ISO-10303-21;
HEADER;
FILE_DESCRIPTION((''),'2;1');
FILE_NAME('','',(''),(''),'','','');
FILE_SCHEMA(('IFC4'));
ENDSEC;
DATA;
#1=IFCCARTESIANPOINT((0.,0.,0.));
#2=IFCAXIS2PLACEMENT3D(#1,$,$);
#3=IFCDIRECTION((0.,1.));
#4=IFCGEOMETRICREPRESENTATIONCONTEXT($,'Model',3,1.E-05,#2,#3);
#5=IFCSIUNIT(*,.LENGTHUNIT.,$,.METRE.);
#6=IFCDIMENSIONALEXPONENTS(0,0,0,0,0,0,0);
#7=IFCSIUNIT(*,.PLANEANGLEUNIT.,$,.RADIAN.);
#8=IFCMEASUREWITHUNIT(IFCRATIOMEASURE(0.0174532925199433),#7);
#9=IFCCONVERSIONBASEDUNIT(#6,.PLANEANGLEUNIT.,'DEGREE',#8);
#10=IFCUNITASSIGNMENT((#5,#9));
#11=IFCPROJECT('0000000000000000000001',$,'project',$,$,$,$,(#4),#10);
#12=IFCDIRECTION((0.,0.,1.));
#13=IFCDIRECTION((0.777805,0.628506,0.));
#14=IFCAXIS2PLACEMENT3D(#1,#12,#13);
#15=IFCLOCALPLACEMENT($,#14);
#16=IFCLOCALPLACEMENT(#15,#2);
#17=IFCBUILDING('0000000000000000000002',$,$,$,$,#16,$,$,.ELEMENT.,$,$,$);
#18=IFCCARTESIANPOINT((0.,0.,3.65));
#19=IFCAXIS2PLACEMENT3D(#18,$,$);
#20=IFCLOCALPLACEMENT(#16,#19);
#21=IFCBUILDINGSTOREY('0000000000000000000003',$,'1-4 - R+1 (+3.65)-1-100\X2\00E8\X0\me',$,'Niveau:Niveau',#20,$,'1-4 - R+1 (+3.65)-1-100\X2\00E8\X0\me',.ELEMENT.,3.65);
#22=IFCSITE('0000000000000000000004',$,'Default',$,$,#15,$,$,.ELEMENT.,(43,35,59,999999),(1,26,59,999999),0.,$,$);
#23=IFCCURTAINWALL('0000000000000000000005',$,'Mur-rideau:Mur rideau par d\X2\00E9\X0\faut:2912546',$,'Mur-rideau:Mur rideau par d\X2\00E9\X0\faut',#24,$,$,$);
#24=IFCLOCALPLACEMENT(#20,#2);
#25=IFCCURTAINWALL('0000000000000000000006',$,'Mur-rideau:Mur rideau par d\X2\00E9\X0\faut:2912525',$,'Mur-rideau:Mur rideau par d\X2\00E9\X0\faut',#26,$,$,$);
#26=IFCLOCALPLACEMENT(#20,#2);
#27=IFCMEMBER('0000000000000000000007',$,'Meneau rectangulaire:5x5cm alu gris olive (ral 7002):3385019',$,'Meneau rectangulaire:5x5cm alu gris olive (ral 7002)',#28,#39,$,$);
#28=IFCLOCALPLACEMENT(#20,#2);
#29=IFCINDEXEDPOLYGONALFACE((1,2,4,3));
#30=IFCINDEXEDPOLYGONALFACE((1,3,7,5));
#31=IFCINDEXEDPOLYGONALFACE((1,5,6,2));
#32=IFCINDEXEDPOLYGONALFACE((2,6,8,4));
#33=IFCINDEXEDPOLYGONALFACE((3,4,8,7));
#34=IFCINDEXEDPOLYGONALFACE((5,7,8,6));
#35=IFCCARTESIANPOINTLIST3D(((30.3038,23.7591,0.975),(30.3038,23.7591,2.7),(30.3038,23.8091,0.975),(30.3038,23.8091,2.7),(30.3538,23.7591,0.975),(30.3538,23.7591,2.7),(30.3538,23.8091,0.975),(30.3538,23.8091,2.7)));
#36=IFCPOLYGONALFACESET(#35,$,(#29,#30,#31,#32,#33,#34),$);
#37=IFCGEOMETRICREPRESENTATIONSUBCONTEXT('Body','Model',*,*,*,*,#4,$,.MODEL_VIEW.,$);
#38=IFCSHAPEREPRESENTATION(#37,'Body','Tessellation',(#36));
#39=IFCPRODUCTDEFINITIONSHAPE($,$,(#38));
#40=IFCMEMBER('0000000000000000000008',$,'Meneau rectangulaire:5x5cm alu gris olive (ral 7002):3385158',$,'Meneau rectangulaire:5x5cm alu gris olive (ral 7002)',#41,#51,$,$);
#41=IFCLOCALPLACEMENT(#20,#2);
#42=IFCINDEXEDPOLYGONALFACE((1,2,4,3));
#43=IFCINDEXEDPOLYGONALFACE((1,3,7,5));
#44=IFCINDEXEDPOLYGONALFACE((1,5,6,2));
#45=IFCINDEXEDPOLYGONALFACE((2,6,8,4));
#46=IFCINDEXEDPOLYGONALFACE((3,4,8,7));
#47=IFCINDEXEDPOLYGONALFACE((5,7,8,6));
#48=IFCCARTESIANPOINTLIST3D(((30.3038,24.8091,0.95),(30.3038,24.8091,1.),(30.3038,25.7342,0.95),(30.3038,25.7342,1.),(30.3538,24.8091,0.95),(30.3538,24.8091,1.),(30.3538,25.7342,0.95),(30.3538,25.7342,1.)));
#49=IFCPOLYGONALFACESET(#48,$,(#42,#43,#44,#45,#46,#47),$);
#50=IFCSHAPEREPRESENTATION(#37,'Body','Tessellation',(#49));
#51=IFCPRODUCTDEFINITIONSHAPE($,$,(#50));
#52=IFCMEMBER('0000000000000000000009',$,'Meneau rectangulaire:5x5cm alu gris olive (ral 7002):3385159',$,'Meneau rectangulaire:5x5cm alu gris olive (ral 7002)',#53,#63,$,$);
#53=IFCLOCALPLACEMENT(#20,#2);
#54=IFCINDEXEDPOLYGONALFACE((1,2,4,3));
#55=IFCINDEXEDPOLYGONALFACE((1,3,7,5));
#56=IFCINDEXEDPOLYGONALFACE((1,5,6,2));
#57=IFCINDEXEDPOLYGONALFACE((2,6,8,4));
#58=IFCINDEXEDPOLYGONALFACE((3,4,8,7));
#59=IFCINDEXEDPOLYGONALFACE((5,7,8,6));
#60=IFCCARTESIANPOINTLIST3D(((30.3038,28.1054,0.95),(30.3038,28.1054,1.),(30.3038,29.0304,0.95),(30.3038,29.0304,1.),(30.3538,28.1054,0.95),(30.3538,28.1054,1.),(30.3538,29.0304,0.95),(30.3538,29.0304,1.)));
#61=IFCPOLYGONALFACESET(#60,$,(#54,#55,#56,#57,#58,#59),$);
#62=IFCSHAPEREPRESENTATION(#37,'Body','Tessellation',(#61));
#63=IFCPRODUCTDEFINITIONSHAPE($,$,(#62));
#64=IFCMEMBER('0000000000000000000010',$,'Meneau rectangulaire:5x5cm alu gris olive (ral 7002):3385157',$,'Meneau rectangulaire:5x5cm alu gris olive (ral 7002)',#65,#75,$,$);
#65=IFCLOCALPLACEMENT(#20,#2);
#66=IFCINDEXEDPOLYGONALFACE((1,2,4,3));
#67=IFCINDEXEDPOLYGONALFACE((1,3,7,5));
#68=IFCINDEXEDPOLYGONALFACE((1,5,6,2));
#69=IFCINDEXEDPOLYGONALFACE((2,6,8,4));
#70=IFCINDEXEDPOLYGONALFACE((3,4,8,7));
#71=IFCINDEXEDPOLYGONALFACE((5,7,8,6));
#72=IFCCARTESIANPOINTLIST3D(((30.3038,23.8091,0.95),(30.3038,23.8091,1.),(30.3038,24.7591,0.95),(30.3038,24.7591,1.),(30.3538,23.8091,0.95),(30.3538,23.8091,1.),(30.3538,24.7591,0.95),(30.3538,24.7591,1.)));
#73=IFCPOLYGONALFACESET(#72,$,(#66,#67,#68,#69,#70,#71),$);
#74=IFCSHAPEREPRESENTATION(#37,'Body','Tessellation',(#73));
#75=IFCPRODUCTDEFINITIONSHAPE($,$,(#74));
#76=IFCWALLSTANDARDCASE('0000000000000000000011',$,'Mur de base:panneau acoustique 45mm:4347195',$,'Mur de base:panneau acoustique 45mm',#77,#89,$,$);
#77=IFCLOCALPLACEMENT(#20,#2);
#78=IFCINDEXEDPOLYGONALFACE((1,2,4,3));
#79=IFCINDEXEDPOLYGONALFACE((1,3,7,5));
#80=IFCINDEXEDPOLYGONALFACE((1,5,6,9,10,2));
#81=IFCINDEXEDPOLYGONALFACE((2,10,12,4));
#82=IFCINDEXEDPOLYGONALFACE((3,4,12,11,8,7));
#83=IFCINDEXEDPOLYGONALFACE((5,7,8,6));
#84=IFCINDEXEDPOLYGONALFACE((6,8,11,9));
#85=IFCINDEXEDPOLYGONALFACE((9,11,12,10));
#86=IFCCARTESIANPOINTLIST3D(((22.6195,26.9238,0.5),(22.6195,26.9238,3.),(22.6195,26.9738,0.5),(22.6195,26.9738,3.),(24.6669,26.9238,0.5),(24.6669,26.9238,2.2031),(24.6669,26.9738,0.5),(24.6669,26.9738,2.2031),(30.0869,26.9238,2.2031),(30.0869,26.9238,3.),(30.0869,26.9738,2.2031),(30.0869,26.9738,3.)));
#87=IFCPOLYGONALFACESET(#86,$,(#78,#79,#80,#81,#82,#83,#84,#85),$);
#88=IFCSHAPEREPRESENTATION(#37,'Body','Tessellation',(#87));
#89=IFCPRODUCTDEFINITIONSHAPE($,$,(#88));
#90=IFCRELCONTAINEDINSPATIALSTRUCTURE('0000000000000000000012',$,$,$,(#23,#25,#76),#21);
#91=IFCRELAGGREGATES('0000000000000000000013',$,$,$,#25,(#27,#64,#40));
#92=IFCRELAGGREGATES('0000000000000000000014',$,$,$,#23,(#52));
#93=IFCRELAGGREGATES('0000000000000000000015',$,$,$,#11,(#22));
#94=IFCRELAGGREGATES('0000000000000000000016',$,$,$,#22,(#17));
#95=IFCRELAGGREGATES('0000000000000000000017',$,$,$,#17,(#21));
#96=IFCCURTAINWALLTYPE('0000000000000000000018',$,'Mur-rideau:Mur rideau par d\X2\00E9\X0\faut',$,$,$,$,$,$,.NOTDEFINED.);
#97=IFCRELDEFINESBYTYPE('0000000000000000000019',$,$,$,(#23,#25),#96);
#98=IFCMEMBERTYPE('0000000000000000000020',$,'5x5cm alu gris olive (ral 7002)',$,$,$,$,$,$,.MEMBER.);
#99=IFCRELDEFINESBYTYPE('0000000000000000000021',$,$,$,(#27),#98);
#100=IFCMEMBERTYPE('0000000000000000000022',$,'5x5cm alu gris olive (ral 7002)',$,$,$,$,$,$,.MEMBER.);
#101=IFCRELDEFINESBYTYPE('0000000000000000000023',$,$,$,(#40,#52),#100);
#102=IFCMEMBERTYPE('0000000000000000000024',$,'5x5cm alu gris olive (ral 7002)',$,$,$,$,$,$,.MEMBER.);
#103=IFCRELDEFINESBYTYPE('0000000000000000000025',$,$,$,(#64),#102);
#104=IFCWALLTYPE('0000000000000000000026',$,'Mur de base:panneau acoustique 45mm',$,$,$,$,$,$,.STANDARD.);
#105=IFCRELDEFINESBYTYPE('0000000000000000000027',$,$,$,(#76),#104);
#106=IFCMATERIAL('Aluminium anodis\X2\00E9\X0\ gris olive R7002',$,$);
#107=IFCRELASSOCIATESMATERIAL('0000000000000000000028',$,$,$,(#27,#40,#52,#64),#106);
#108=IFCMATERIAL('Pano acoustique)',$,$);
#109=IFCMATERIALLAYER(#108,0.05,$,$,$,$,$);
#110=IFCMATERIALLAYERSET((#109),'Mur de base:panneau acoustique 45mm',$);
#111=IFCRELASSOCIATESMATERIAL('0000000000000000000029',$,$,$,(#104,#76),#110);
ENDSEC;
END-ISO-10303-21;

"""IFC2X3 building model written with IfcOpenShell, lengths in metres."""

from ifc_helpers import new_model, entity, si_unit, converted_unit, direction, frame, frame_2d, origin, origin_2d_with_axis, place, context, subcontext, project, spatial, rectangle, extrude, source, transform, mapped, material, layer, layer_set, layer_usage, type_object, type_shapes, element, aggregate, save


model = new_model("IFC2X3")

# Units and contexts
model_context = context("Model", 3, precision=1e-05, world=origin(), true_north=direction((0.0, 1.0)))
body_context = subcontext(model_context, "Body", "Model", "MODEL_VIEW")
ifc_project = project(units=[si_unit("LENGTHUNIT", "METRE"), converted_unit("PLANEANGLEUNIT", "DEGREE", entity("IfcRatioMeasure", 0.0174532925199433), si_unit("PLANEANGLEUNIT", "RADIAN"), dimensions=[0, 0, 0, 0, 0, 0, 0])], contexts=[model_context])

# Site, building, storey
site_placement = place(None, frame((0.0, 0.0, 0.0), z_axis=(0.0, 0.0, 1.0), x_axis=(0.777805, 0.628506, 0.0)))
site = spatial("IfcSite", under=ifc_project, at=site_placement, Name="Default", CompositionType="ELEMENT", RefLatitude=(43, 35, 59, 999999), RefLongitude=(1, 26, 59, 999999), RefElevation=0.0)
building_placement = place(site_placement, origin())
building = spatial("IfcBuilding", under=site, at=building_placement, CompositionType="ELEMENT")
storey_placement = place(building_placement, frame((0.0, 0.0, 3.65)))
storey = spatial("IfcBuildingStorey", under=building, at=storey_placement, Name="1-4 - R+1 (+3.65)-1-100ème", ObjectType="Niveau:Niveau", LongName="1-4 - R+1 (+3.65)-1-100ème", CompositionType="ELEMENT", Elevation=3.65)

# Curtain wall
curtain_wall_type = type_object("IfcCurtainWallType", Name="Mur-rideau:Mur rideau par défaut", PredefinedType="NOTDEFINED")
curtain_wall_1_placement = place(storey_placement, frame((0.0, 0.0, -3.65)))
curtain_wall_1 = element("IfcCurtainWall", 1, at=curtain_wall_1_placement, inside=storey, type_object=curtain_wall_type, Name="Mur-rideau:Mur rideau par défaut:2912546", ObjectType="Mur-rideau:Mur rideau par défaut")
ifc_material_1 = material(Name="Aluminium anodisé gris olive R7002")

# Curtain wall
curtain_wall_2_placement = place(storey_placement, frame((0.0, 0.0, -3.65)))
curtain_wall_2 = element("IfcCurtainWall", 2, at=curtain_wall_2_placement, inside=storey, type_object=curtain_wall_type, Name="Mur-rideau:Mur rideau par défaut:2912525", ObjectType="Mur-rideau:Mur rideau par défaut")

# Members
member_type_1 = type_object("IfcMemberType", Name="5x5cm alu gris olive (ral 7002)", PredefinedType="MEMBER")
shared_shape_1 = source(origin(), body_context, "Body", "SweptSolid", [
    extrude(rectangle(XDim=0.05, YDim=0.05, at=origin_2d_with_axis()), frame((0.0, 0.0, -1.725), z_axis=(0.0, 0.0, 1.0), x_axis=(0.0, -1.0, 0.0)), (0.0, 0.0, 1.0), 1.725),
])
type_shapes(member_type_1, [shared_shape_1])
member_1_placement = place(storey_placement, frame((30.3288, 23.7841, 0.975), z_axis=(0.0, 0.0, -1.0), x_axis=(0.0, -1.0, 0.0)))
member_1 = element("IfcMember", 3, at=member_1_placement, type_object=member_type_1, material=ifc_material_1, Name="Meneau rectangulaire:5x5cm alu gris olive (ral 7002):3385019", ObjectType="Meneau rectangulaire:5x5cm alu gris olive (ral 7002)", context=body_context, shape_type="MappedRepresentation", body=[
    mapped(shared_shape_1, transform((0.0, 0.0, 0.0), scale=1.0)),
])
member_type_2 = type_object("IfcMemberType", Name="5x5cm alu gris olive (ral 7002)", PredefinedType="MEMBER")
shared_shape_2 = source(origin(), body_context, "Body", "SweptSolid", [
    extrude(rectangle(XDim=0.05, YDim=0.05, at=origin_2d_with_axis()), frame((0.0, 0.0, -0.925), z_axis=(0.0, 0.0, 1.0), x_axis=(0.0, -1.0, 0.0)), (0.0, 0.0, 1.0), 0.925),
])
type_shapes(member_type_2, [shared_shape_2])
member_2_placement = place(storey_placement, frame((30.3288, 24.8091, 0.975), z_axis=(0.0, -1.0, 0.0), x_axis=(0.0, 0.0, 1.0)))
member_2 = element("IfcMember", 4, at=member_2_placement, type_object=member_type_2, material=ifc_material_1, Name="Meneau rectangulaire:5x5cm alu gris olive (ral 7002):3385158", ObjectType="Meneau rectangulaire:5x5cm alu gris olive (ral 7002)", context=body_context, shape_type="MappedRepresentation", body=[
    mapped(shared_shape_2, transform((0.0, 0.0, 0.0), scale=1.0)),
])
member_3_placement = place(storey_placement, frame((30.3288, 28.1054, 0.975), z_axis=(0.0, -1.0, 0.0), x_axis=(0.0, 0.0, 1.0)))
member_3 = element("IfcMember", 5, at=member_3_placement, type_object=member_type_2, material=ifc_material_1, Name="Meneau rectangulaire:5x5cm alu gris olive (ral 7002):3385159", ObjectType="Meneau rectangulaire:5x5cm alu gris olive (ral 7002)", context=body_context, shape_type="MappedRepresentation", body=[
    mapped(shared_shape_2, transform((0.0, 0.0, 0.0), scale=1.0)),
])
member_type_3 = type_object("IfcMemberType", Name="5x5cm alu gris olive (ral 7002)", PredefinedType="MEMBER")
shared_shape_3 = source(origin(), body_context, "Body", "SweptSolid", [
    extrude(rectangle(XDim=0.05, YDim=0.05, at=origin_2d_with_axis()), frame((0.0, 0.0, -0.95), z_axis=(0.0, 0.0, 1.0), x_axis=(0.0, -1.0, 0.0)), (0.0, 0.0, 1.0), 0.95),
])
type_shapes(member_type_3, [shared_shape_3])
member_4_placement = place(storey_placement, frame((30.3288, 23.8091, 0.975), z_axis=(0.0, -1.0, 0.0), x_axis=(0.0, 0.0, 1.0)))
member_4 = element("IfcMember", 6, at=member_4_placement, type_object=member_type_3, material=ifc_material_1, Name="Meneau rectangulaire:5x5cm alu gris olive (ral 7002):3385157", ObjectType="Meneau rectangulaire:5x5cm alu gris olive (ral 7002)", context=body_context, shape_type="MappedRepresentation", body=[
    mapped(shared_shape_3, transform((0.0, 0.0, 0.0), scale=1.0)),
])

aggregate(curtain_wall_2, [member_1, member_4, member_2])
aggregate(curtain_wall_1, [member_3])

# Wall, opening
ifc_material_2 = material(Name="Pano acoustique)")
ifc_layer_1 = layer(ifc_material_2, 0.05)
ifc_layer_set_1 = layer_set([ifc_layer_1], Name="Mur de base:panneau acoustique 45mm")
ifc_layer_usage_1 = layer_usage(ifc_layer_set_1, "AXIS2", "POSITIVE", -0.025)
wall_type = type_object("IfcWallType", Name="Mur de base:panneau acoustique 45mm", PredefinedType="STANDARD", material=ifc_layer_set_1)
wall_placement = place(storey_placement, frame((30.0869, 26.9488, 0.5), z_axis=(0.0, 0.0, 1.0), x_axis=(-1.0, 0.0, 0.0)))
wall = element("IfcWallStandardCase", 7, at=wall_placement, inside=storey, type_object=wall_type, material=ifc_layer_usage_1, Name="Mur de base:panneau acoustique 45mm:4347195", ObjectType="Mur de base:panneau acoustique 45mm", context=body_context, shape_type="SweptSolid", body=[
    extrude(rectangle(XDim=7.4674, YDim=0.05, at=frame_2d((3.7337, 0.0), x_axis=(-1.0, 0.0))), origin(), (0.0, 0.0, 1.0), 2.5),
])
opening_placement = place(wall_placement, origin())
element("IfcOpeningElement", 8, at=opening_placement, cuts=wall, ObjectType="Opening", context=body_context, shape_type="SweptSolid", body=[
    extrude(rectangle(XDim=1.7031, YDim=5.42, at=frame_2d((0.0, 0.0), x_axis=(1.0, 0.0))), frame((2.71, 0.025, 0.8515), z_axis=(0.0, -1.0, 0.0), x_axis=(0.0, 0.0, 1.0)), (0.0, 0.0, 1.0), 0.05),
])

save(model, "model.ifc")
